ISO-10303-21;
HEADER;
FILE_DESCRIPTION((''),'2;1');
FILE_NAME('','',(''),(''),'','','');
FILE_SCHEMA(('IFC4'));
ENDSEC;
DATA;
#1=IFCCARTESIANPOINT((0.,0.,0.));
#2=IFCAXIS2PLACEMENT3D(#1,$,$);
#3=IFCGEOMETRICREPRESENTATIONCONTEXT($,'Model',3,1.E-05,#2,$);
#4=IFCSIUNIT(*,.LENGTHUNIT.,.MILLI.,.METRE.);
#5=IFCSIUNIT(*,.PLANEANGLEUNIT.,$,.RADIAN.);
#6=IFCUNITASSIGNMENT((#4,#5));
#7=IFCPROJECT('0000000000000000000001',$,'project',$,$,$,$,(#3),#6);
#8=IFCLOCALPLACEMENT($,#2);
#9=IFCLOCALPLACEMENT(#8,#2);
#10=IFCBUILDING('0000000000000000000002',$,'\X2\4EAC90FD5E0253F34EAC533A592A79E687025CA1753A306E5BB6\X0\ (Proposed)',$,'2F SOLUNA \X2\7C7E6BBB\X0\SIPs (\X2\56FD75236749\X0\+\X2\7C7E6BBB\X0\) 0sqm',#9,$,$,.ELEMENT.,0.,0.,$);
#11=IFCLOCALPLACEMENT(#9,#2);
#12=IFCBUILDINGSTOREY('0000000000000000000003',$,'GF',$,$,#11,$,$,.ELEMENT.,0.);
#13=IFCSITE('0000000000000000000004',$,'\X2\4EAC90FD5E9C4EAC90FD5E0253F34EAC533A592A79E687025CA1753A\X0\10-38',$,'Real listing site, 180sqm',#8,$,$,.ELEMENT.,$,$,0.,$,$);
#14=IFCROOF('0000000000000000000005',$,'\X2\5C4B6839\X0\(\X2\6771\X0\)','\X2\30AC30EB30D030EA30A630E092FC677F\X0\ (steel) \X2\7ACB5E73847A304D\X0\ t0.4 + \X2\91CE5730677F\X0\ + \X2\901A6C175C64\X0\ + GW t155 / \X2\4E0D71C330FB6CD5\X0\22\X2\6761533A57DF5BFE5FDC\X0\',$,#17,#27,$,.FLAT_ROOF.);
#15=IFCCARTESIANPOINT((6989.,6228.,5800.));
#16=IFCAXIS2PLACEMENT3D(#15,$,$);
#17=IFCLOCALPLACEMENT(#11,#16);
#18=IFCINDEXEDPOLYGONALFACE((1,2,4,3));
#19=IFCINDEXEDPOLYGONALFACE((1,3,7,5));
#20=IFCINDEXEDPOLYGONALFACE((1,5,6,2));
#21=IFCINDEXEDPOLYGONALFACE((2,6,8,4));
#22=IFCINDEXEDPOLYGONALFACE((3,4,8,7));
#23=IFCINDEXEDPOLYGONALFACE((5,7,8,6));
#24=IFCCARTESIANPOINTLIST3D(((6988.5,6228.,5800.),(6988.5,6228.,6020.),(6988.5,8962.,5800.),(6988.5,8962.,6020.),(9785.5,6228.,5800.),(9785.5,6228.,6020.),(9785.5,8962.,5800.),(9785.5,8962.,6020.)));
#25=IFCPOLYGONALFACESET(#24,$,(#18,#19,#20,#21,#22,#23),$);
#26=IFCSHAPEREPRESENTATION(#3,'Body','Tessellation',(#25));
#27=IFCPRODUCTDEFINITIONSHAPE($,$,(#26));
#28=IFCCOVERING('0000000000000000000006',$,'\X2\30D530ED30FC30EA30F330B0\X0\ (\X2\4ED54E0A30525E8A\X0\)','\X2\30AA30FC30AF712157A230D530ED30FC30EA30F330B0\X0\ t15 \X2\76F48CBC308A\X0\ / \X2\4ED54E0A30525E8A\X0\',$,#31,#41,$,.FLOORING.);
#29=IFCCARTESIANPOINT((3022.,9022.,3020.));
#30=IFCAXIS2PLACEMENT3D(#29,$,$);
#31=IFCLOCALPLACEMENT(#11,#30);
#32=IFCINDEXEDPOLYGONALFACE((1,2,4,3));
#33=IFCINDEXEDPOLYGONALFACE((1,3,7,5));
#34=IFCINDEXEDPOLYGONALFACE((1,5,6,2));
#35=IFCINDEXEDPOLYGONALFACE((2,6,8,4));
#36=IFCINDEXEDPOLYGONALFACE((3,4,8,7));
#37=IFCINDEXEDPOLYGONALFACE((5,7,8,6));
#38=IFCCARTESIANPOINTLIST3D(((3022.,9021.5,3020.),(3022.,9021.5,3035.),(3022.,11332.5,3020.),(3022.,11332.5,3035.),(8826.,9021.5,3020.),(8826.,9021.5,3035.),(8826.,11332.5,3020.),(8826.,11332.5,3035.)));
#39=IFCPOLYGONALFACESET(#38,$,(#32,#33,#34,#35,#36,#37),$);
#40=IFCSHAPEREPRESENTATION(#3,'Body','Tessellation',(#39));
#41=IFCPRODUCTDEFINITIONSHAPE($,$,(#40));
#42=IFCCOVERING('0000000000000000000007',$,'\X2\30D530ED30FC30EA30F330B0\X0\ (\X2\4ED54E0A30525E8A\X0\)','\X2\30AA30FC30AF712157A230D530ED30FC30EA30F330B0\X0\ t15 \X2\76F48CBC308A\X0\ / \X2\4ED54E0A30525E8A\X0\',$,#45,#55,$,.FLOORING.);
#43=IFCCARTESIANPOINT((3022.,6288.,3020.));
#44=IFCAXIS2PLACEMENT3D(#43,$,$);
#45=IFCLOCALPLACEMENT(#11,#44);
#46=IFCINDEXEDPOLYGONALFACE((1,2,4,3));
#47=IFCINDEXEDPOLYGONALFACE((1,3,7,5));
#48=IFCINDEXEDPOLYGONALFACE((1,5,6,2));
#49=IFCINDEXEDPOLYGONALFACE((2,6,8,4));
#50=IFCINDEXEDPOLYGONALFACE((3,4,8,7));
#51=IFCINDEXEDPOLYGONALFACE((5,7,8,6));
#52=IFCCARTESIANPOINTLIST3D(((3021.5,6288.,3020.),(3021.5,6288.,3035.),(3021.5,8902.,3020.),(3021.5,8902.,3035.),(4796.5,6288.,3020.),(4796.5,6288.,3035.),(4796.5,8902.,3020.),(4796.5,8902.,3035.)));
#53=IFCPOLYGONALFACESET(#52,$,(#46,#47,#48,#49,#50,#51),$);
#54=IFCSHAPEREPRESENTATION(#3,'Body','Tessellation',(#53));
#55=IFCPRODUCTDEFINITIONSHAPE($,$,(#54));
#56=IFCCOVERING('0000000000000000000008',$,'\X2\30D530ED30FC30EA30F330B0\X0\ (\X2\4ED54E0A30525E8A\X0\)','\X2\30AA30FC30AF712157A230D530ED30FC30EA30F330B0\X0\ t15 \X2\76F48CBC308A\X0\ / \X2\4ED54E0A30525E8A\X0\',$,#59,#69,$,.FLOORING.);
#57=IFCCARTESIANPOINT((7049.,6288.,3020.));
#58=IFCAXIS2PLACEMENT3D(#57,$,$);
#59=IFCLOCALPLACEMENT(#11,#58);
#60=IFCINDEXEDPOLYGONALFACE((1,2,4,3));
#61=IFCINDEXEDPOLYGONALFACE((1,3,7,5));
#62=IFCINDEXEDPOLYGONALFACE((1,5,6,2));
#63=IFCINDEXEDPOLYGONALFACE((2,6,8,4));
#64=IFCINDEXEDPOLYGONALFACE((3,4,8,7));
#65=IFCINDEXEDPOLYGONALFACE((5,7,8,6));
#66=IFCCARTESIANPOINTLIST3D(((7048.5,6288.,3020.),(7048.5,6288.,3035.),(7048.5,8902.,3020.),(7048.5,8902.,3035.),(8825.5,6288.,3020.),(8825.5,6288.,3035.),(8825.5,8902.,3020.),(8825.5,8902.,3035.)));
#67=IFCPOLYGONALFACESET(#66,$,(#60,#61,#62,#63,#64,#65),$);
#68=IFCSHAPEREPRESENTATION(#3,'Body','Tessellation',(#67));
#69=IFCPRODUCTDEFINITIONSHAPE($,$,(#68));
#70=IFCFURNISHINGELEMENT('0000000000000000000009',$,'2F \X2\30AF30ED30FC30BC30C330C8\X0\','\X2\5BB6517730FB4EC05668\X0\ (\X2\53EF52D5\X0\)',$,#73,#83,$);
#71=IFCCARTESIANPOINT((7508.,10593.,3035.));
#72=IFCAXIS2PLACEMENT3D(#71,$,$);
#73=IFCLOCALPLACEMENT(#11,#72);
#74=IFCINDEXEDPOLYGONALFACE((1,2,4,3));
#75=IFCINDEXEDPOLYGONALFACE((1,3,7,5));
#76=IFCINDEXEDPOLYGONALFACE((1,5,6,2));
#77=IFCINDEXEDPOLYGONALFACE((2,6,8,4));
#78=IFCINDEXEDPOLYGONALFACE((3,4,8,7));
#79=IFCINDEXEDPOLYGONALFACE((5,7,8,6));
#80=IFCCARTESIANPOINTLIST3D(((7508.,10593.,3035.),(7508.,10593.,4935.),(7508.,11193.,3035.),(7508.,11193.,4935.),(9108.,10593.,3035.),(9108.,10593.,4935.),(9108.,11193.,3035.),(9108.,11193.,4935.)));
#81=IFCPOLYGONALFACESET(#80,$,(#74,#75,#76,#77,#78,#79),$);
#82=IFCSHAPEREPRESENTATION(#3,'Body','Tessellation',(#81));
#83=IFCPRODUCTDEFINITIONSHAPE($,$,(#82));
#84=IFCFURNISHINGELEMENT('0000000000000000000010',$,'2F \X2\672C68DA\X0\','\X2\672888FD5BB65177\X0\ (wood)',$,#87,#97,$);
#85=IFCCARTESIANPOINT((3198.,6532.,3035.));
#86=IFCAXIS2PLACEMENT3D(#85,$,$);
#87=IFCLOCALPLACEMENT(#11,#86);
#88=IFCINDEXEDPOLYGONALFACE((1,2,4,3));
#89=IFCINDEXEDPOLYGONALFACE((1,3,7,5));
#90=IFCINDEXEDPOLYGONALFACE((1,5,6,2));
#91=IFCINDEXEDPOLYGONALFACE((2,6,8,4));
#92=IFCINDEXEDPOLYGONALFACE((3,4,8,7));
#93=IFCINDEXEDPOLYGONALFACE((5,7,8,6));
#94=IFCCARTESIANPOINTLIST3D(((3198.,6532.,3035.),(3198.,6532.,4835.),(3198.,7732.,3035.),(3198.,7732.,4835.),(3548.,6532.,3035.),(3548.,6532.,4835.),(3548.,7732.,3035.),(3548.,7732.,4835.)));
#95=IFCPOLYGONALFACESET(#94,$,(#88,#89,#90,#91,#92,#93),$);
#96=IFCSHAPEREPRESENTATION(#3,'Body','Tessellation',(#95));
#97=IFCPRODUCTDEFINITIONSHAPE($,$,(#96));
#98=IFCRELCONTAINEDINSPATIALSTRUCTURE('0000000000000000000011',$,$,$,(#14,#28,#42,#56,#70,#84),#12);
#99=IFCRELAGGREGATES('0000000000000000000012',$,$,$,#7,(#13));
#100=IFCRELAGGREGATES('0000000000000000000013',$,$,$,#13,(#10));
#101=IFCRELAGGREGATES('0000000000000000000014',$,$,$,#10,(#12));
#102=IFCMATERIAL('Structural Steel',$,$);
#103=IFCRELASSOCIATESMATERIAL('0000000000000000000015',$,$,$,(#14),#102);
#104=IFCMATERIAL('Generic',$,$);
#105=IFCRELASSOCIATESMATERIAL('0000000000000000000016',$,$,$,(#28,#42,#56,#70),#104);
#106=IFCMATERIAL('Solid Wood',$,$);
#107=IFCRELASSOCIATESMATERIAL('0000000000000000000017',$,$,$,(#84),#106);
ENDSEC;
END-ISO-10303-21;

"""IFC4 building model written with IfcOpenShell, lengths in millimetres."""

from ifc_helpers import new_model, si_unit, frame, frame_2d, origin, place, context, project, spatial, rectangle, extrude, material, element, save


model = new_model("IFC4")

# Units and contexts
model_context = context("Model", 3, precision=1e-05, world=origin())
ifc_project = project(units=[si_unit("LENGTHUNIT", "METRE", prefix="MILLI"), si_unit("PLANEANGLEUNIT", "RADIAN")], contexts=[model_context])

# Site, building, storey
site_placement = place(None, origin())
site = spatial("IfcSite", under=ifc_project, at=site_placement, Name="京都府京都市右京区太秦蜂岡町10-38", ObjectType="Real listing site, 180sqm", CompositionType="ELEMENT", RefElevation=0.0)
building_placement = place(site_placement, origin())
building = spatial("IfcBuilding", under=site, at=building_placement, Name="京都市右京区太秦蜂岡町の家 (Proposed)", ObjectType="2F SOLUNA 籾殻SIPs (国産杉+籾殻) 0sqm", CompositionType="ELEMENT", ElevationOfRefHeight=0.0, ElevationOfTerrain=0.0)
storey_placement = place(building_placement, origin())
storey = spatial("IfcBuildingStorey", under=building, at=storey_placement, Name="GF", CompositionType="ELEMENT", Elevation=0.0)

# Shared definitions
ifc_material_1 = material(Name="Solid Wood")

# Roof
ifc_material_2 = material(Name="Structural Steel")
roof_1_placement = place(storey_placement, frame((6989.0, 6228.0, 5800.0)))
element("IfcRoof", 1, at=roof_1_placement, inside=storey, material=ifc_material_2, Name="屋根(東)", Description="ガルバリウム鋼板 (steel) 立平葺き t0.4 + 野地板 + 通気層 + GW t155 / 不燃・法22条区域対応", PredefinedType="FLAT_ROOF", context=model_context, shape_type="SweptSolid", body=[
    extrude(rectangle(XDim=2797.0, YDim=2734.0, at=frame_2d((1398.0, 1367.0))), frame((6989.0, 6228.0, 5800.0)), (0.0, 0.0, 1.0), 220.0),
])

# Coverings
ifc_material_3 = material(Name="Generic")
covering_1_placement = place(storey_placement, frame((3022.0, 9022.0, 3020.0)))
element("IfcCovering", 2, at=covering_1_placement, inside=storey, material=ifc_material_3, Name="フローリング (仕上げ床)", Description="オーク無垢フローリング t15 直貼り / 仕上げ床", PredefinedType="FLOORING", context=model_context, shape_type="SweptSolid", body=[
    extrude(rectangle(XDim=5804.0, YDim=2311.0, at=frame_2d((2902.0, 1155.0))), frame((3022.0, 9022.0, 3020.0)), (0.0, 0.0, 1.0), 15.0),
])
covering_2_placement = place(storey_placement, frame((3022.0, 6288.0, 3020.0)))
element("IfcCovering", 3, at=covering_2_placement, inside=storey, material=ifc_material_3, Name="フローリング (仕上げ床)", Description="オーク無垢フローリング t15 直貼り / 仕上げ床", PredefinedType="FLOORING", context=model_context, shape_type="SweptSolid", body=[
    extrude(rectangle(XDim=1775.0, YDim=2614.0, at=frame_2d((887.0, 1307.0))), frame((3022.0, 6288.0, 3020.0)), (0.0, 0.0, 1.0), 15.0),
])
covering_3_placement = place(storey_placement, frame((7049.0, 6288.0, 3020.0)))
element("IfcCovering", 4, at=covering_3_placement, inside=storey, material=ifc_material_3, Name="フローリング (仕上げ床)", Description="オーク無垢フローリング t15 直貼り / 仕上げ床", PredefinedType="FLOORING", context=model_context, shape_type="SweptSolid", body=[
    extrude(rectangle(XDim=1777.0, YDim=2614.0, at=frame_2d((888.0, 1307.0))), frame((7049.0, 6288.0, 3020.0)), (0.0, 0.0, 1.0), 15.0),
])

# Furnishing elements
furnishing_1_placement = place(storey_placement, frame((7508.0, 10593.0, 3035.0)))
element("IfcFurnishingElement", 5, at=furnishing_1_placement, inside=storey, material=ifc_material_3, Name="2F クローゼット", Description="家具・什器 (可動)", context=model_context, shape_type="SweptSolid", body=[
    extrude(rectangle(XDim=1600.0, YDim=600.0, at=frame_2d((800.0, 300.0))), frame((7508.0, 10593.0, 3035.0)), (0.0, 0.0, 1.0), 1900.0),
])
furnishing_2_placement = place(storey_placement, frame((3198.0, 6532.0, 3035.0)))
element("IfcFurnishingElement", 6, at=furnishing_2_placement, inside=storey, material=ifc_material_1, Name="2F 本棚", Description="木製家具 (wood)", context=model_context, shape_type="SweptSolid", body=[
    extrude(rectangle(XDim=350.0, YDim=1200.0, at=frame_2d((175.0, 600.0))), frame((3198.0, 6532.0, 3035.0)), (0.0, 0.0, 1.0), 1800.0),
])

save(model, "model.ifc")
